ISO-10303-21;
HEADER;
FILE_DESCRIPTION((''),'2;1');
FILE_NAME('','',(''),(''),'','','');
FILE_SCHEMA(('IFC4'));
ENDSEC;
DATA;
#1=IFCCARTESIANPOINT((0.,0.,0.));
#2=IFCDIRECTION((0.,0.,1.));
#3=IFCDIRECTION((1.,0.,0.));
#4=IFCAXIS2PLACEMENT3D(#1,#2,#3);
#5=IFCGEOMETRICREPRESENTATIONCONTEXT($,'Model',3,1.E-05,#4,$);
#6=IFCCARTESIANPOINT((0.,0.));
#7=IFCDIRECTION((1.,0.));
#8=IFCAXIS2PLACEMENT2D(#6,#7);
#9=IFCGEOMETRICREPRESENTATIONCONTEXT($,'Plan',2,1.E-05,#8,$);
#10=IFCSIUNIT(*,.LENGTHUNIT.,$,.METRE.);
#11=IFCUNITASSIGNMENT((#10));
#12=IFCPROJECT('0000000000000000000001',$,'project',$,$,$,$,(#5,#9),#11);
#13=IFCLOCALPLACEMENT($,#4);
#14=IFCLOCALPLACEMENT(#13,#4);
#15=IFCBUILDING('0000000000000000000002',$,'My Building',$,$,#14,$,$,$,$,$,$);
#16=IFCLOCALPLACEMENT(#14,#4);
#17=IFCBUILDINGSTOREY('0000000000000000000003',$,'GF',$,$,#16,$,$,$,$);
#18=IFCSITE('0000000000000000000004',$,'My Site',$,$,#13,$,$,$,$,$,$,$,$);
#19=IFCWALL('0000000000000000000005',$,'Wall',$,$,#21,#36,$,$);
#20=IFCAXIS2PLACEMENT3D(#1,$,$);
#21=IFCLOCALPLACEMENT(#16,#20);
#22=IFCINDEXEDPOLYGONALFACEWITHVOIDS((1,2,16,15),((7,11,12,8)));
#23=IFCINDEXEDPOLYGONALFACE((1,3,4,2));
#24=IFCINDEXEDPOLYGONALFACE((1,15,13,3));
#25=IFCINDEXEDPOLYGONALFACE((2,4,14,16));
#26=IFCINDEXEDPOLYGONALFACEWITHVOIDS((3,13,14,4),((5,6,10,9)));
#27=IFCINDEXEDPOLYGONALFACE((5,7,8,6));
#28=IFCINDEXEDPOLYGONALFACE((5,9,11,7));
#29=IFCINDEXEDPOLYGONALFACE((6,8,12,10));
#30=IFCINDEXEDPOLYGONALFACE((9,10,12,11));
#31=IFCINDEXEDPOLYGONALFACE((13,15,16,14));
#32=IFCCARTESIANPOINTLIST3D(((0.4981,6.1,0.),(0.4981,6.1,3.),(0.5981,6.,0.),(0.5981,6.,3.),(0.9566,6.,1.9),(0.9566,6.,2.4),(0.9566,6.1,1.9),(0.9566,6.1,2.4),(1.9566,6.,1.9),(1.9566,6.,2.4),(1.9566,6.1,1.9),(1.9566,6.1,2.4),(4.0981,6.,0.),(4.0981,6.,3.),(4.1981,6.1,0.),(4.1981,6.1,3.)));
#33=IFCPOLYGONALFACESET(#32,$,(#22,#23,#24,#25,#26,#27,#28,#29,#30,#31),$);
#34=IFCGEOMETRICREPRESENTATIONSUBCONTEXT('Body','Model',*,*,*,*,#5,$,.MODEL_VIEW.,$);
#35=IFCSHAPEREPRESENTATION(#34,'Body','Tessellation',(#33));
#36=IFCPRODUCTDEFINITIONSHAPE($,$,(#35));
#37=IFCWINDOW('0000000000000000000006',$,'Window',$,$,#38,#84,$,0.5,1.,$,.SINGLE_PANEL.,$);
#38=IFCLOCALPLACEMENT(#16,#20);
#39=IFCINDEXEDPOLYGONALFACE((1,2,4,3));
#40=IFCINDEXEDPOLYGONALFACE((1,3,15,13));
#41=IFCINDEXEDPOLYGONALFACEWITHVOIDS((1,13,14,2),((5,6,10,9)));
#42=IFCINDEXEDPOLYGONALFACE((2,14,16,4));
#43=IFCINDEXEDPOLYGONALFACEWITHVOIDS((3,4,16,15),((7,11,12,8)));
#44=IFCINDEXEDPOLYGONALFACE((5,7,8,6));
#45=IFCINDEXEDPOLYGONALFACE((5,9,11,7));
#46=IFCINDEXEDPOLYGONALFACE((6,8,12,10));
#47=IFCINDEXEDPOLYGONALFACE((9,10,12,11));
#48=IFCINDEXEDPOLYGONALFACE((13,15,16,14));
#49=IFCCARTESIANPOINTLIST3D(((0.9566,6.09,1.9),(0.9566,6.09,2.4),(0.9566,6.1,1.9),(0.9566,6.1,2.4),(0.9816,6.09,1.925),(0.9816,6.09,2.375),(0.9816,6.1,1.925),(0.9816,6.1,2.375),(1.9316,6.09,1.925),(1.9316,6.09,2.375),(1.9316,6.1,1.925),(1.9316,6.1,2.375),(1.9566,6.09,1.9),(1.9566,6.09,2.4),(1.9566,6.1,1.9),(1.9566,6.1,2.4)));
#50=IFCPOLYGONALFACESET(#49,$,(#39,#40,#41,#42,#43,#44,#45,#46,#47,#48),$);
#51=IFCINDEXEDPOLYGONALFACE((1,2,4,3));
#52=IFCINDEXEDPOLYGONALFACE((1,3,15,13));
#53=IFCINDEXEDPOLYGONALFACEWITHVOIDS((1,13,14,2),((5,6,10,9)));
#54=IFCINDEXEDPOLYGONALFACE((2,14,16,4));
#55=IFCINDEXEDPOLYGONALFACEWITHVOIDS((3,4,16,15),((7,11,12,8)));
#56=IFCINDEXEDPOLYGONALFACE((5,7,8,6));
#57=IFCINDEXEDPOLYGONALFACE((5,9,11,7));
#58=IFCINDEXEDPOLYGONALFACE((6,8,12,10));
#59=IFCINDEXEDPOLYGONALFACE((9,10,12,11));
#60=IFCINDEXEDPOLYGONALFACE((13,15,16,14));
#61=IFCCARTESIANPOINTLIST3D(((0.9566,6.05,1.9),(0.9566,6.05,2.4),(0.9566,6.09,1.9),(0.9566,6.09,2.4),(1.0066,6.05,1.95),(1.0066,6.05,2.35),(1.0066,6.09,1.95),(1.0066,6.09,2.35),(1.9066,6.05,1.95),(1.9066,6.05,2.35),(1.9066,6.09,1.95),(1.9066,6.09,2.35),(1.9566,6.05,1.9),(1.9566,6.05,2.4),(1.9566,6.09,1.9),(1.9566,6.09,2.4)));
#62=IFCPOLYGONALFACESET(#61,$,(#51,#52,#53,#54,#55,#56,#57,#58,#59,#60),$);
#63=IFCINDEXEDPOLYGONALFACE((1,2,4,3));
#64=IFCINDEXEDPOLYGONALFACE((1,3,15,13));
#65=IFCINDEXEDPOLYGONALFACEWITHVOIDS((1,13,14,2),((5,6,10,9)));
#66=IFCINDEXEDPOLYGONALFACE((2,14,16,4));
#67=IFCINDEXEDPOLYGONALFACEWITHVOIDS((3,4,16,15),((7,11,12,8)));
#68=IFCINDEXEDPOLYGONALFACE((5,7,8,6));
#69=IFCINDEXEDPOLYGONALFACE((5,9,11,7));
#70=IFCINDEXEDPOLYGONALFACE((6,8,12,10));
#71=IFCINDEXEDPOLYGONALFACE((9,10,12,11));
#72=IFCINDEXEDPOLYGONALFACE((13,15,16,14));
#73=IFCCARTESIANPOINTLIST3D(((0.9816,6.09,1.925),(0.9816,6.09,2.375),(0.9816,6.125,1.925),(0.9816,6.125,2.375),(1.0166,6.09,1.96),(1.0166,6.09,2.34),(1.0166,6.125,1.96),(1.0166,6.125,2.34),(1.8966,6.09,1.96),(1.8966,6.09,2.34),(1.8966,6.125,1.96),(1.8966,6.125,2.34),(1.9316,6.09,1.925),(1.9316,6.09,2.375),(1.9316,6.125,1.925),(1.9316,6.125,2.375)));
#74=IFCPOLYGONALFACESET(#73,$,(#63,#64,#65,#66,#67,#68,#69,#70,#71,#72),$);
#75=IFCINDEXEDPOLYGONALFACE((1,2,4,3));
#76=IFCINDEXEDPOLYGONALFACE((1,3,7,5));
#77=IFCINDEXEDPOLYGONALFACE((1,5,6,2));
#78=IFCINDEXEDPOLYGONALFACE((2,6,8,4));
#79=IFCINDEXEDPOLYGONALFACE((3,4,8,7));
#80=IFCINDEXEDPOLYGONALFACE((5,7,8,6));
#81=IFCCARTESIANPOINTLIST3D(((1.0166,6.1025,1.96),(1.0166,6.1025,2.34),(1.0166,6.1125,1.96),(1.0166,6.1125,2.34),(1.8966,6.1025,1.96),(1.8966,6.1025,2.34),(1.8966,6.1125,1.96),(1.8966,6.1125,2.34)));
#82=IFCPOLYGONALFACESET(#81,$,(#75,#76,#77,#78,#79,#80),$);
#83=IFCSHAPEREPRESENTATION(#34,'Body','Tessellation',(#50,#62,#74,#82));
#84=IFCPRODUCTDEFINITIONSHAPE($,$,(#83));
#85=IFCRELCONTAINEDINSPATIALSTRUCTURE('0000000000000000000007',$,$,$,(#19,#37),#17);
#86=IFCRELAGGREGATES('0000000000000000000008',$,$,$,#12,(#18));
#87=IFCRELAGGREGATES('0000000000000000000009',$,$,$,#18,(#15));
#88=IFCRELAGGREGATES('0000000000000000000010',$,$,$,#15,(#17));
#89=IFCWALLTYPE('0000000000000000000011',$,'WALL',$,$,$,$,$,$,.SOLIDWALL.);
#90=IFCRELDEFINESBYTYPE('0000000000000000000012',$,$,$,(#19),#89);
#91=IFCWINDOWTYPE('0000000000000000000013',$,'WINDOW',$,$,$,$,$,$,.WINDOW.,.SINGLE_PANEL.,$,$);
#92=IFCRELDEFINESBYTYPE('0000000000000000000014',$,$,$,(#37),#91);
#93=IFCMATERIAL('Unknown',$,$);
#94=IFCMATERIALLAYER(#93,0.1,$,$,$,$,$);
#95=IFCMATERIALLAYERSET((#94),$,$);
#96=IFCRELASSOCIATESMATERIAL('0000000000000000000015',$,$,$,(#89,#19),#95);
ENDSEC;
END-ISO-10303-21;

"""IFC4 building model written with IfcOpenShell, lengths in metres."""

from ifc_helpers import new_model, entity, si_unit, frame, origin_with_axes, origin_2d_with_axis, place, context, subcontext, project, spatial, line, indexed_curve, outline, extrude, shape, source, transform, mapped, material, layer, layer_set, layer_usage, type_object, type_shapes, element, fill, save


model = new_model("IFC4")

# Units and contexts
model_context = context("Model", 3, precision=1e-05, world=origin_with_axes())
plan_context = context("Plan", 2, precision=1e-05, world=origin_2d_with_axis())
body_context_1 = subcontext(model_context, "Body", "Model", "MODEL_VIEW")
body_context_2 = subcontext(plan_context, "Body", "Plan", "PLAN_VIEW")
ifc_project = project(units=[si_unit("LENGTHUNIT", "METRE")], contexts=[model_context, plan_context])

# Site, building, storey
site_placement = place(None, origin_with_axes())
site = spatial("IfcSite", under=ifc_project, at=site_placement, Name="My Site")
building_placement = place(site_placement, origin_with_axes())
building = spatial("IfcBuilding", under=site, at=building_placement, Name="My Building")
storey_placement = place(building_placement, origin_with_axes())
storey = spatial("IfcBuildingStorey", under=building, at=storey_placement, Name="GF")

# Shared definitions
ifc_material = material(Name="Unknown")

# Shared definitions
ifc_layer_1 = layer(ifc_material, 0.1)
ifc_layer_set_1 = layer_set([ifc_layer_1])
wall_type_1 = type_object("IfcWallType", Name="WALL", PredefinedType="SOLIDWALL", material=ifc_layer_set_1)

# Wall, opening, window
ifc_layer_usage_1 = layer_usage(ifc_layer_set_1, "AXIS2", "POSITIVE", 0.0)
wall_1_placement = place(storey_placement, frame((0.5981, 6.0, 0.0), z_axis=(0.0, 0.0, 1.0), x_axis=(1.0, 0.0, 0.0)))
wall_1 = element("IfcWall", 1, at=wall_1_placement, inside=storey, type_object=wall_type_1, material=ifc_layer_usage_1, Name="Wall", context=body_context_1, shape_type="SweptSolid", body=[
    extrude(outline(indexed_curve([(0.0, 0.0), (-0.1, 0.1), (3.6, 0.1), (3.5, 0.0)], segments=[line(1, 2, 3, 4, 1)])), origin_with_axes(), (0.0, 0.0, 1.0), 3.0),
])
shared_shape_1 = source(origin_with_axes(), body_context_1, "Body", "SweptSolid", [
    extrude(outline(indexed_curve([(0.0, 0.0), (1.0, 0.0), (1.0, 0.5), (0.0, 0.5)], segments=[line(1, 2, 3, 4, 1)])), frame((0.0, -0.6, 0.0), z_axis=(0.0, -1.0, 0.0), x_axis=(1.0, 0.0, 0.0)), (0.0, 0.0, -1.0), 1.2),
])
opening_1_placement = place(wall_1_placement, frame((0.3586, 0.0, 1.9), z_axis=(0.0, 0.0, 1.0), x_axis=(1.0, 0.0, 0.0)))
opening_1 = element("IfcOpeningElement", 2, at=opening_1_placement, cuts=wall_1, PredefinedType="OPENING", context=body_context_1, shape_type="MappedRepresentation", body=[
    mapped(shared_shape_1, transform((0.0, 0.0, 0.0), x_axis=(1.0, 0.0, 0.0), y_axis=(0.0, 1.0, 0.0), z_axis=(0.0, 0.0, 1.0), scale=1.0)),
])
window_type = type_object("IfcWindowType", Name="WINDOW", PartitioningType="SINGLE_PANEL", PredefinedType="WINDOW")
shared_shape_2 = source(origin_with_axes(), body_context_1, "Body", "SweptSolid", [
    extrude(outline(indexed_curve([(0.0, 0.0), (1.0, 0.0), (1.0, 0.5), (0.0, 0.5)], segments=[line(1, 2, 3, 4, 1)]), holes=[indexed_curve([(0.025, 0.025), (0.975, 0.025), (0.975, 0.475), (0.025, 0.475)], segments=[line(1, 2, 3, 4, 1)])]), frame((0.0, 0.09, 0.0), z_axis=(0.0, -1.0, 0.0), x_axis=(1.0, 0.0, 0.0)), (0.0, 0.0, -1.0), 0.01),
    extrude(outline(indexed_curve([(0.0, 0.0), (1.0, 0.0), (1.0, 0.5), (0.0, 0.5)], segments=[line(1, 2, 3, 4, 1)]), holes=[indexed_curve([(0.05, 0.05), (0.95, 0.05), (0.95, 0.45), (0.05, 0.45)], segments=[line(1, 2, 3, 4, 1)])]), frame((0.0, 0.05, 0.0), z_axis=(0.0, -1.0, 0.0), x_axis=(1.0, 0.0, 0.0)), (0.0, 0.0, -1.0), 0.04),
    extrude(outline(indexed_curve([(0.0, 0.0), (0.95, 0.0), (0.95, 0.45), (0.0, 0.45)], segments=[line(1, 2, 3, 4, 1)]), holes=[indexed_curve([(0.035, 0.035), (0.915, 0.035), (0.915, 0.415), (0.035, 0.415)], segments=[line(1, 2, 3, 4, 1)])]), frame((0.025, 0.09, 0.025), z_axis=(0.0, -1.0, 0.0), x_axis=(1.0, 0.0, 0.0)), (0.0, 0.0, -1.0), 0.035),
    extrude(outline(indexed_curve([(0.035, 0.035), (0.915, 0.035), (0.915, 0.415), (0.035, 0.415)], segments=[line(1, 2, 3, 4, 1)])), frame((0.025, 0.1025, 0.025), z_axis=(0.0, -1.0, 0.0), x_axis=(1.0, 0.0, 0.0)), (0.0, 0.0, -1.0), 0.01),
])
shared_shape_3 = source(origin_with_axes(), body_context_2, "Body", "Curve2D", [
    entity("IfcIndexedPolyCurve", entity("IfcCartesianPointList2D", [[0.05, 0.05], [0.95, 0.05]])),
    entity("IfcIndexedPolyCurve", entity("IfcCartesianPointList2D", [[0.0, 0.1], [0.025, 0.1], [0.025, 0.09], [0.05, 0.09], [0.05, 0.05], [0.0, 0.05]]), [entity("IfcLineIndex", [1, 2, 3, 4, 5, 6, 1])]),
    entity("IfcIndexedPolyCurve", entity("IfcCartesianPointList2D", [[1.0, 0.1], [0.975, 0.1], [0.975, 0.09], [0.95, 0.09], [0.95, 0.05], [1.0, 0.05]]), [entity("IfcLineIndex", [1, 2, 3, 4, 5, 6, 1])]),
    entity("IfcIndexedPolyCurve", entity("IfcCartesianPointList2D", [[0.025, 0.09], [0.06, 0.09], [0.06, 0.125], [0.025, 0.125]]), [entity("IfcLineIndex", [1, 2, 3, 4, 1])]),
    entity("IfcIndexedPolyCurve", entity("IfcCartesianPointList2D", [[0.975, 0.09], [0.94, 0.09], [0.94, 0.125], [0.975, 0.125]]), [entity("IfcLineIndex", [1, 2, 3, 4, 1])]),
    entity("IfcIndexedPolyCurve", entity("IfcCartesianPointList2D", [[0.06, 0.09], [0.94, 0.09]])),
    entity("IfcIndexedPolyCurve", entity("IfcCartesianPointList2D", [[0.06, 0.125], [0.94, 0.125]])),
    entity("IfcIndexedPolyCurve", entity("IfcCartesianPointList2D", [[0.06, 0.1075], [0.94, 0.1075]])),
])
type_shapes(window_type, [shared_shape_2, shared_shape_3])
window_placement = place(opening_1_placement, frame((0.0, 0.0, 0.0), z_axis=(0.0, 0.0, 1.0), x_axis=(1.0, 0.0, 0.0)))
window = element("IfcWindow", 3, at=window_placement, inside=storey, type_object=window_type, Name="Window", OverallHeight=0.5, OverallWidth=1.0, PartitioningType="SINGLE_PANEL", shapes=[
    shape(body_context_1, "Body", "MappedRepresentation", [mapped(shared_shape_2, transform((0.0, 0.0, 0.0), x_axis=(1.0, 0.0, 0.0), y_axis=(0.0, 1.0, 0.0), z_axis=(0.0, 0.0, 1.0), scale=1.0))]),
    shape(body_context_2, "Body", "MappedRepresentation", [mapped(shared_shape_3, transform((0.0, 0.0, 0.0), x_axis=(1.0, 0.0, 0.0), y_axis=(0.0, 1.0, 0.0), z_axis=(0.0, 0.0, 1.0), scale=1.0))]),
])
fill(opening_1, window)

save(model, "model.ifc")
